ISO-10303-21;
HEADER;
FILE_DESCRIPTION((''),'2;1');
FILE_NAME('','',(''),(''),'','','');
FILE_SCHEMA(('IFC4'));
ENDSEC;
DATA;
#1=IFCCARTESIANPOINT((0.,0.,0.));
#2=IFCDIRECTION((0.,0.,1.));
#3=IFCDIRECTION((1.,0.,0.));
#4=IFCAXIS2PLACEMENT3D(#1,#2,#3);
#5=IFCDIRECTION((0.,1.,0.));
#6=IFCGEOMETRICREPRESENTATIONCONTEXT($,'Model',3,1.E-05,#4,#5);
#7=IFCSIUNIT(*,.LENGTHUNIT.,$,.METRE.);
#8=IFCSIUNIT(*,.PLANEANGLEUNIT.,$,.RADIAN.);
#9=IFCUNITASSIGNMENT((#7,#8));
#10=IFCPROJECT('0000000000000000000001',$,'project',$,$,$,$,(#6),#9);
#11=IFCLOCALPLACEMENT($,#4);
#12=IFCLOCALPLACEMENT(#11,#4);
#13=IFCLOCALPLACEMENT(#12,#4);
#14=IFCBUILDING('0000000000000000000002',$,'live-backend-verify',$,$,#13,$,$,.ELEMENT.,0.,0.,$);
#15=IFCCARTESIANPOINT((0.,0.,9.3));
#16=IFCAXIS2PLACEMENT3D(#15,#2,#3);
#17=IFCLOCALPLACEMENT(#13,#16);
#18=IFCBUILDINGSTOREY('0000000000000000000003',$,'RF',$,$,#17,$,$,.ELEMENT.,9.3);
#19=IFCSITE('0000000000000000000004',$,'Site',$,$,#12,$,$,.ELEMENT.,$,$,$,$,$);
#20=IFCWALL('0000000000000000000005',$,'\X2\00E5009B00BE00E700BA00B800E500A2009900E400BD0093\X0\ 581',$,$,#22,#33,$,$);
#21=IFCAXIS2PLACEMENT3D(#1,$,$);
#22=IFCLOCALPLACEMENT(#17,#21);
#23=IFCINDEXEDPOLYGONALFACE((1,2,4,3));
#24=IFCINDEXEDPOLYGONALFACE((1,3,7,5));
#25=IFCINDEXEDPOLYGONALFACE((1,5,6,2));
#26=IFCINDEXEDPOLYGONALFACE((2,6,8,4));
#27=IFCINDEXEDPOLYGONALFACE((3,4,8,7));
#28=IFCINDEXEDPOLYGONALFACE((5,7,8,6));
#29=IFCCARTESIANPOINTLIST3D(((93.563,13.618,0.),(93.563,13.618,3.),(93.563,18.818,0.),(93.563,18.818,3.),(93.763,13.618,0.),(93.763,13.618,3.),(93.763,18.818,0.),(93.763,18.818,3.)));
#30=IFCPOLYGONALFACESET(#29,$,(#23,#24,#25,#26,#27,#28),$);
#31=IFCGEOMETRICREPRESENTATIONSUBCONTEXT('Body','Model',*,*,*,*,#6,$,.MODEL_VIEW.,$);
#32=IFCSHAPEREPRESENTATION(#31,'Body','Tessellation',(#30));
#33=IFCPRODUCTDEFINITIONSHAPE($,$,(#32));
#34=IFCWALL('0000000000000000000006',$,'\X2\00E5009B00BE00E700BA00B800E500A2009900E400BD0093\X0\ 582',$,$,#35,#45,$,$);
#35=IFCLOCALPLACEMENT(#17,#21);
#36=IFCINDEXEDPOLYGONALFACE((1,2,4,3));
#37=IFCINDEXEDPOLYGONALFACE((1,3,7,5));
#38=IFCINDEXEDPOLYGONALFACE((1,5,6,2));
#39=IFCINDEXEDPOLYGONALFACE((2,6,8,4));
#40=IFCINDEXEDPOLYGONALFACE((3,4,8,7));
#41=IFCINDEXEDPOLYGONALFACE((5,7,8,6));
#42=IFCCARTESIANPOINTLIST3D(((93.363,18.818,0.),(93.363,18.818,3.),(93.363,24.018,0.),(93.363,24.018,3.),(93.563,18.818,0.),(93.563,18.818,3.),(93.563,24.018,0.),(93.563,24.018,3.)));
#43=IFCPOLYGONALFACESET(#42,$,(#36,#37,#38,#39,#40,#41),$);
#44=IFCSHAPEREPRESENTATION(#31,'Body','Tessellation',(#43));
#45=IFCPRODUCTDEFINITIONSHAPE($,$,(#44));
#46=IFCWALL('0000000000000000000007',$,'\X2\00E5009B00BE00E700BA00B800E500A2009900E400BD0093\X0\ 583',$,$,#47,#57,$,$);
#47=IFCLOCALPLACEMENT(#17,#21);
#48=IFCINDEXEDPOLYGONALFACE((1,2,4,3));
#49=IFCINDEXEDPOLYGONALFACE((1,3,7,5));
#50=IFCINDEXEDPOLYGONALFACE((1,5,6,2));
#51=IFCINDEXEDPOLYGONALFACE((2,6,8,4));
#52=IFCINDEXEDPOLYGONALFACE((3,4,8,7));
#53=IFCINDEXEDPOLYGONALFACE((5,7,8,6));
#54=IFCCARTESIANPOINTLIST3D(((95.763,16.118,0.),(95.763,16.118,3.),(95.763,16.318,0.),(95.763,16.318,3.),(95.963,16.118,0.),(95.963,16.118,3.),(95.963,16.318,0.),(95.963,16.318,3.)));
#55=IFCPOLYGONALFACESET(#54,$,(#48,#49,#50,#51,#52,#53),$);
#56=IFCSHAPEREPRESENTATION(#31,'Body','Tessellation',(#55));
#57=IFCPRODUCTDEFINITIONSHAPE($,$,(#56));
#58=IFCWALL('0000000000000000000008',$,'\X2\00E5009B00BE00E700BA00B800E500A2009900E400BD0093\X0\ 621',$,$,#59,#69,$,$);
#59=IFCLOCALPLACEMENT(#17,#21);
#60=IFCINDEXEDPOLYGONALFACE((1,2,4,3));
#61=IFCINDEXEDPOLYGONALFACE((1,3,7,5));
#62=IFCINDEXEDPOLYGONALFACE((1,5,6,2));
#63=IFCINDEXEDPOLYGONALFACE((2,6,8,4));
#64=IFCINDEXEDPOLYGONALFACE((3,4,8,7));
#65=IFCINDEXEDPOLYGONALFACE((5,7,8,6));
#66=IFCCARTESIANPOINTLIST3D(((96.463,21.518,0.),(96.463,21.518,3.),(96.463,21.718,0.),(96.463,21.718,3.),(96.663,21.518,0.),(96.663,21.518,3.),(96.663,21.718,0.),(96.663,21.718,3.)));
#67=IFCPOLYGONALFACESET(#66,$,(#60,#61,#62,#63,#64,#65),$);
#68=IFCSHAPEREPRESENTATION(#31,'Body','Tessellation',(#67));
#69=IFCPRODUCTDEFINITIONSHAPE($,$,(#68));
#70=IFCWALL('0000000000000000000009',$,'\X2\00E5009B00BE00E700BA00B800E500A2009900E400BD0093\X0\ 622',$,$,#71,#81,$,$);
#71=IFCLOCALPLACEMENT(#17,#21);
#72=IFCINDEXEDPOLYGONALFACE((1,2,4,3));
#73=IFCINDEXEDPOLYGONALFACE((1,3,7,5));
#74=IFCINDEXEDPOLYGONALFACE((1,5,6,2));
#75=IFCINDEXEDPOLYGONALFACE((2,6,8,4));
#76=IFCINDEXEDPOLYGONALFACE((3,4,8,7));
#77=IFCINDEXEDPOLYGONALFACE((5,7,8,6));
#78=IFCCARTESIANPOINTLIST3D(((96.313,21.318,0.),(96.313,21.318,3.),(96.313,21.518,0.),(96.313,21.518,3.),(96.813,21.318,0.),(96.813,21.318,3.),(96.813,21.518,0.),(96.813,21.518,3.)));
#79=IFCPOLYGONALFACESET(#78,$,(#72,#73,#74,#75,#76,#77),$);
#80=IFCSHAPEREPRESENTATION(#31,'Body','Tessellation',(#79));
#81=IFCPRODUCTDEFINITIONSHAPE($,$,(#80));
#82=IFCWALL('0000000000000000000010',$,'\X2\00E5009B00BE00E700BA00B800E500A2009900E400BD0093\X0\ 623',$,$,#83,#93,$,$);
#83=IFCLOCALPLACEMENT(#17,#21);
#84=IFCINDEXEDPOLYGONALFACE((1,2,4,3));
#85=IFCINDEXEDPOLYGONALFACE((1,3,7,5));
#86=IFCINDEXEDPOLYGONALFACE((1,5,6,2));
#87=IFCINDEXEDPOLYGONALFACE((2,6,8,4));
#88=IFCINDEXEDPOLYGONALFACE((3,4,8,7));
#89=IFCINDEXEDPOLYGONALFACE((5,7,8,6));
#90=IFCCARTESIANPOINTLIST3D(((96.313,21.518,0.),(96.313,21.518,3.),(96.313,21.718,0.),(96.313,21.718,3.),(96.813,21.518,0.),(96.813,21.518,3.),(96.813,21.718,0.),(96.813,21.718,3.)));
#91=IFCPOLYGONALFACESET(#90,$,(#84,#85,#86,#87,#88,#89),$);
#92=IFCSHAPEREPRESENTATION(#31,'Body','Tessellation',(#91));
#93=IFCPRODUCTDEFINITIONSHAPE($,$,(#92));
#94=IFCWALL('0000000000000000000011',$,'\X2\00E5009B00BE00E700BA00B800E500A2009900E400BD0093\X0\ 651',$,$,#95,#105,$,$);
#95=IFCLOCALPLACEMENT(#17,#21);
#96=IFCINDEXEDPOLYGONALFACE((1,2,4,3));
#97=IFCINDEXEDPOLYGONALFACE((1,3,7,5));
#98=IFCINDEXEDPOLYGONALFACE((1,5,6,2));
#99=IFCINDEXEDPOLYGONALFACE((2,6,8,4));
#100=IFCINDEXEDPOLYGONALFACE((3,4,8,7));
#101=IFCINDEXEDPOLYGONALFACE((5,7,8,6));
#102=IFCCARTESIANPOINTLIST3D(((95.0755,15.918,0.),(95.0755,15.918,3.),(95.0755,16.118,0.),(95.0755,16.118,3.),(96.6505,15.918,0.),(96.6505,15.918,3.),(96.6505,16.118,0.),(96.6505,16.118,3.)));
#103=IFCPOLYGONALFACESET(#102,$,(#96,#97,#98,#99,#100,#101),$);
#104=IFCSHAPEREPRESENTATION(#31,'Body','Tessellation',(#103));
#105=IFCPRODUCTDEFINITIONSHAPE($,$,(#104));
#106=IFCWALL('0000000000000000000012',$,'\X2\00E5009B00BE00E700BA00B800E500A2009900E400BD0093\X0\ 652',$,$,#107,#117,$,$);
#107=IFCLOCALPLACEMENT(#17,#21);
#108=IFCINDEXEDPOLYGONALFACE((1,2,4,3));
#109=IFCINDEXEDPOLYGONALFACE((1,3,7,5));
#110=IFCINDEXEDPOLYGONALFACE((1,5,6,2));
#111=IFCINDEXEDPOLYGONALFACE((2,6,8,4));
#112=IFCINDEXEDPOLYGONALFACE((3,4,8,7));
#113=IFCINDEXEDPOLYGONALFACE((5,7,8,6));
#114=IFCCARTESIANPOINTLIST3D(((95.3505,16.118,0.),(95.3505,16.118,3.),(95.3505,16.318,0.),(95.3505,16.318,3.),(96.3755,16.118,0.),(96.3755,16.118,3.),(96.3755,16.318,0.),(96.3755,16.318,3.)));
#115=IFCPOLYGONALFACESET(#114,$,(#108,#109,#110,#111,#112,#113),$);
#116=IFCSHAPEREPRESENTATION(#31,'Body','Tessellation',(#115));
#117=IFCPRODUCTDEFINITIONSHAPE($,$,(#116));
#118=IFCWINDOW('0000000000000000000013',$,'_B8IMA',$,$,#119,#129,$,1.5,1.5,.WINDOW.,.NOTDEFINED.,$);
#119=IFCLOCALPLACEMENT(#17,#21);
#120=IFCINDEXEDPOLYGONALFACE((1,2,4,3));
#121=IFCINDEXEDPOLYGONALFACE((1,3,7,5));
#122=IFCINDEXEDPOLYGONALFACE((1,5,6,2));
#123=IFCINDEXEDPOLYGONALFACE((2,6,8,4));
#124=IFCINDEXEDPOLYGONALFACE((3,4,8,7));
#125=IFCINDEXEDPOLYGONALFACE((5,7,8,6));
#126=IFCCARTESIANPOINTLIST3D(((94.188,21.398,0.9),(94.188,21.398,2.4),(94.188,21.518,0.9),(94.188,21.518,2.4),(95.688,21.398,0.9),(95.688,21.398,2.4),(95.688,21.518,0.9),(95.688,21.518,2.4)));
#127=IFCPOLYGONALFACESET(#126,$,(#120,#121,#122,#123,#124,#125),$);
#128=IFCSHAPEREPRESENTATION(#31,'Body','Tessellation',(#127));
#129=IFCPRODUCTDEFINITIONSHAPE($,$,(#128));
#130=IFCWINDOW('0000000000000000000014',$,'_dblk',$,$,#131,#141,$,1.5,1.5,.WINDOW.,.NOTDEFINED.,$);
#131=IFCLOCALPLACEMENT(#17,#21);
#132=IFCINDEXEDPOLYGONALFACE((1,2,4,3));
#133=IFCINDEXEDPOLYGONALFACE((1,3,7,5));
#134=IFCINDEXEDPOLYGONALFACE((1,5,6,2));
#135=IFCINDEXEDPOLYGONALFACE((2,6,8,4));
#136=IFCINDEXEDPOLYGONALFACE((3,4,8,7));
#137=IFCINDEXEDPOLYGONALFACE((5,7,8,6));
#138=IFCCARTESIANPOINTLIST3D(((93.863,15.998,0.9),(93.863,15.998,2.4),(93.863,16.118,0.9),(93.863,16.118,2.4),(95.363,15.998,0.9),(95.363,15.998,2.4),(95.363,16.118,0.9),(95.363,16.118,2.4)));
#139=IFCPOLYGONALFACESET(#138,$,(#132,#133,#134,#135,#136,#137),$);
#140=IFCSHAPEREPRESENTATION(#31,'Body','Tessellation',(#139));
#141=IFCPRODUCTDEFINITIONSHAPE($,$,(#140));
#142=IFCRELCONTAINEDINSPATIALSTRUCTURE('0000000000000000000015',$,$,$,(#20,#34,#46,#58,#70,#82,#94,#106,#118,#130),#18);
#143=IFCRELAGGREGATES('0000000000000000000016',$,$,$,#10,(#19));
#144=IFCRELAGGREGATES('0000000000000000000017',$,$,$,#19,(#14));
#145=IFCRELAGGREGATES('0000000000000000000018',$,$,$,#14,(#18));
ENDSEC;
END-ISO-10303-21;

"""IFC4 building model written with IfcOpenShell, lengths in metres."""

from ifc_helpers import new_model, si_unit, direction, frame, frame_2d, origin_with_axes, place, context, subcontext, project, spatial, rectangle, extrude, element, save


model = new_model("IFC4")

# Units and contexts
model_context = context("Model", 3, precision=1e-05, world=origin_with_axes(), true_north=direction((0.0, 1.0, 0.0)))
body_context = subcontext(model_context, "Body", "Model", "MODEL_VIEW")
ifc_project = project(units=[si_unit("LENGTHUNIT", "METRE"), si_unit("PLANEANGLEUNIT", "RADIAN")], contexts=[model_context])

# Site, building, storey
placement = place(None, origin_with_axes())
site_placement = place(placement, origin_with_axes())
site = spatial("IfcSite", under=ifc_project, at=site_placement, Name="Site", CompositionType="ELEMENT")
building_placement = place(site_placement, origin_with_axes())
building = spatial("IfcBuilding", under=site, at=building_placement, Name="live-backend-verify", CompositionType="ELEMENT", ElevationOfRefHeight=0.0, ElevationOfTerrain=0.0)
storey_placement = place(building_placement, frame((0.0, 0.0, 9.3), z_axis=(0.0, 0.0, 1.0), x_axis=(1.0, 0.0, 0.0)))
storey = spatial("IfcBuildingStorey", under=building, at=storey_placement, Name="RF", CompositionType="ELEMENT", Elevation=9.3)

# Walls
for number, where, z_axis, x_axis, name in (
    (1, (93.663, 16.218, 0.0), (0.0, 0.0, 1.0), (0.0, 1.0, 0.0), "å\u009b¾çº¸å¢\u0099ä½\u0093 581"),
    (2, (93.463, 21.418, 0.0), (0.0, 0.0, 1.0), (0.0, -1.0, 0.0), "å\u009b¾çº¸å¢\u0099ä½\u0093 582"),
):
    element("IfcWall", number, at=place(storey_placement, frame(where, z_axis=z_axis, x_axis=x_axis)), inside=storey, Name=name, context=body_context, shape_type="SweptSolid", body=[
        extrude(rectangle(XDim=5.2, YDim=0.2, at=frame_2d((0.0, 0.0), x_axis=(1.0, 0.0, 0.0))), frame((0.0, 0.0, 0.0), z_axis=(0.0, 0.0, 1.0)), (0.0, 0.0, 1.0), 3.0),
    ])
for number, where, z_axis, x_axis, name in (
    (3, (95.863, 16.218, 0.0), (0.0, 0.0, 1.0), (0.0, -1.0, 0.0), "å\u009b¾çº¸å¢\u0099ä½\u0093 583"),
    (4, (96.563, 21.618, 0.0), (0.0, 0.0, 1.0), (0.0, -1.0, 0.0), "å\u009b¾çº¸å¢\u0099ä½\u0093 621"),
):
    element("IfcWall", number, at=place(storey_placement, frame(where, z_axis=z_axis, x_axis=x_axis)), inside=storey, Name=name, context=body_context, shape_type="SweptSolid", body=[
        extrude(rectangle(XDim=0.2, YDim=0.2, at=frame_2d((0.0, 0.0), x_axis=(1.0, 0.0, 0.0))), frame((0.0, 0.0, 0.0), z_axis=(0.0, 0.0, 1.0)), (0.0, 0.0, 1.0), 3.0),
    ])
for number, where, z_axis, x_axis, name in (
    (5, (96.563, 21.418, 0.0), (0.0, 0.0, 1.0), (1.0, 0.0, 0.0), "å\u009b¾çº¸å¢\u0099ä½\u0093 622"),
    (6, (96.563, 21.618, 0.0), (0.0, 0.0, 1.0), (1.0, 0.0, 0.0), "å\u009b¾çº¸å¢\u0099ä½\u0093 623"),
):
    element("IfcWall", number, at=place(storey_placement, frame(where, z_axis=z_axis, x_axis=x_axis)), inside=storey, Name=name, context=body_context, shape_type="SweptSolid", body=[
        extrude(rectangle(XDim=0.5, YDim=0.2, at=frame_2d((0.0, 0.0), x_axis=(1.0, 0.0, 0.0))), frame((0.0, 0.0, 0.0), z_axis=(0.0, 0.0, 1.0)), (0.0, 0.0, 1.0), 3.0),
    ])
wall_1_placement = place(storey_placement, frame((95.863, 16.018, 0.0), z_axis=(0.0, 0.0, 1.0), x_axis=(1.0, 0.0, 0.0)))
element("IfcWall", 7, at=wall_1_placement, inside=storey, Name="å\u009b¾çº¸å¢\u0099ä½\u0093 651", context=body_context, shape_type="SweptSolid", body=[
    extrude(rectangle(XDim=1.575, YDim=0.2, at=frame_2d((0.0, 0.0), x_axis=(1.0, 0.0, 0.0))), frame((0.0, 0.0, 0.0), z_axis=(0.0, 0.0, 1.0)), (0.0, 0.0, 1.0), 3.0),
])
wall_2_placement = place(storey_placement, frame((95.863, 16.218, 0.0), z_axis=(0.0, 0.0, 1.0), x_axis=(1.0, 0.0, 0.0)))
element("IfcWall", 8, at=wall_2_placement, inside=storey, Name="å\u009b¾çº¸å¢\u0099ä½\u0093 652", context=body_context, shape_type="SweptSolid", body=[
    extrude(rectangle(XDim=1.025, YDim=0.2, at=frame_2d((0.0, 0.0), x_axis=(1.0, 0.0, 0.0))), frame((0.0, 0.0, 0.0), z_axis=(0.0, 0.0, 1.0)), (0.0, 0.0, 1.0), 3.0),
])

# Windows
for number, where, z_axis, x_axis, name in (
    (9, (94.938, 21.458, 0.9), (0.0, 0.0, 1.0), (1.0, 0.0, 0.0), "_B8IMA"),
    (10, (94.613, 16.058, 0.9), (0.0, 0.0, 1.0), (1.0, 0.0, 0.0), "_dblk"),
):
    element("IfcWindow", number, at=place(storey_placement, frame(where, z_axis=z_axis, x_axis=x_axis)), inside=storey, Name=name, OverallHeight=1.5, OverallWidth=1.5, PartitioningType="NOTDEFINED", PredefinedType="WINDOW", context=body_context, shape_type="SweptSolid", body=[
        extrude(rectangle(XDim=1.5, YDim=0.12, at=frame_2d((0.0, 0.0), x_axis=(1.0, 0.0, 0.0))), frame((0.0, 0.0, 0.0), z_axis=(0.0, 0.0, 1.0)), (0.0, 0.0, 1.0), 1.5),
    ])

save(model, "model.ifc")
